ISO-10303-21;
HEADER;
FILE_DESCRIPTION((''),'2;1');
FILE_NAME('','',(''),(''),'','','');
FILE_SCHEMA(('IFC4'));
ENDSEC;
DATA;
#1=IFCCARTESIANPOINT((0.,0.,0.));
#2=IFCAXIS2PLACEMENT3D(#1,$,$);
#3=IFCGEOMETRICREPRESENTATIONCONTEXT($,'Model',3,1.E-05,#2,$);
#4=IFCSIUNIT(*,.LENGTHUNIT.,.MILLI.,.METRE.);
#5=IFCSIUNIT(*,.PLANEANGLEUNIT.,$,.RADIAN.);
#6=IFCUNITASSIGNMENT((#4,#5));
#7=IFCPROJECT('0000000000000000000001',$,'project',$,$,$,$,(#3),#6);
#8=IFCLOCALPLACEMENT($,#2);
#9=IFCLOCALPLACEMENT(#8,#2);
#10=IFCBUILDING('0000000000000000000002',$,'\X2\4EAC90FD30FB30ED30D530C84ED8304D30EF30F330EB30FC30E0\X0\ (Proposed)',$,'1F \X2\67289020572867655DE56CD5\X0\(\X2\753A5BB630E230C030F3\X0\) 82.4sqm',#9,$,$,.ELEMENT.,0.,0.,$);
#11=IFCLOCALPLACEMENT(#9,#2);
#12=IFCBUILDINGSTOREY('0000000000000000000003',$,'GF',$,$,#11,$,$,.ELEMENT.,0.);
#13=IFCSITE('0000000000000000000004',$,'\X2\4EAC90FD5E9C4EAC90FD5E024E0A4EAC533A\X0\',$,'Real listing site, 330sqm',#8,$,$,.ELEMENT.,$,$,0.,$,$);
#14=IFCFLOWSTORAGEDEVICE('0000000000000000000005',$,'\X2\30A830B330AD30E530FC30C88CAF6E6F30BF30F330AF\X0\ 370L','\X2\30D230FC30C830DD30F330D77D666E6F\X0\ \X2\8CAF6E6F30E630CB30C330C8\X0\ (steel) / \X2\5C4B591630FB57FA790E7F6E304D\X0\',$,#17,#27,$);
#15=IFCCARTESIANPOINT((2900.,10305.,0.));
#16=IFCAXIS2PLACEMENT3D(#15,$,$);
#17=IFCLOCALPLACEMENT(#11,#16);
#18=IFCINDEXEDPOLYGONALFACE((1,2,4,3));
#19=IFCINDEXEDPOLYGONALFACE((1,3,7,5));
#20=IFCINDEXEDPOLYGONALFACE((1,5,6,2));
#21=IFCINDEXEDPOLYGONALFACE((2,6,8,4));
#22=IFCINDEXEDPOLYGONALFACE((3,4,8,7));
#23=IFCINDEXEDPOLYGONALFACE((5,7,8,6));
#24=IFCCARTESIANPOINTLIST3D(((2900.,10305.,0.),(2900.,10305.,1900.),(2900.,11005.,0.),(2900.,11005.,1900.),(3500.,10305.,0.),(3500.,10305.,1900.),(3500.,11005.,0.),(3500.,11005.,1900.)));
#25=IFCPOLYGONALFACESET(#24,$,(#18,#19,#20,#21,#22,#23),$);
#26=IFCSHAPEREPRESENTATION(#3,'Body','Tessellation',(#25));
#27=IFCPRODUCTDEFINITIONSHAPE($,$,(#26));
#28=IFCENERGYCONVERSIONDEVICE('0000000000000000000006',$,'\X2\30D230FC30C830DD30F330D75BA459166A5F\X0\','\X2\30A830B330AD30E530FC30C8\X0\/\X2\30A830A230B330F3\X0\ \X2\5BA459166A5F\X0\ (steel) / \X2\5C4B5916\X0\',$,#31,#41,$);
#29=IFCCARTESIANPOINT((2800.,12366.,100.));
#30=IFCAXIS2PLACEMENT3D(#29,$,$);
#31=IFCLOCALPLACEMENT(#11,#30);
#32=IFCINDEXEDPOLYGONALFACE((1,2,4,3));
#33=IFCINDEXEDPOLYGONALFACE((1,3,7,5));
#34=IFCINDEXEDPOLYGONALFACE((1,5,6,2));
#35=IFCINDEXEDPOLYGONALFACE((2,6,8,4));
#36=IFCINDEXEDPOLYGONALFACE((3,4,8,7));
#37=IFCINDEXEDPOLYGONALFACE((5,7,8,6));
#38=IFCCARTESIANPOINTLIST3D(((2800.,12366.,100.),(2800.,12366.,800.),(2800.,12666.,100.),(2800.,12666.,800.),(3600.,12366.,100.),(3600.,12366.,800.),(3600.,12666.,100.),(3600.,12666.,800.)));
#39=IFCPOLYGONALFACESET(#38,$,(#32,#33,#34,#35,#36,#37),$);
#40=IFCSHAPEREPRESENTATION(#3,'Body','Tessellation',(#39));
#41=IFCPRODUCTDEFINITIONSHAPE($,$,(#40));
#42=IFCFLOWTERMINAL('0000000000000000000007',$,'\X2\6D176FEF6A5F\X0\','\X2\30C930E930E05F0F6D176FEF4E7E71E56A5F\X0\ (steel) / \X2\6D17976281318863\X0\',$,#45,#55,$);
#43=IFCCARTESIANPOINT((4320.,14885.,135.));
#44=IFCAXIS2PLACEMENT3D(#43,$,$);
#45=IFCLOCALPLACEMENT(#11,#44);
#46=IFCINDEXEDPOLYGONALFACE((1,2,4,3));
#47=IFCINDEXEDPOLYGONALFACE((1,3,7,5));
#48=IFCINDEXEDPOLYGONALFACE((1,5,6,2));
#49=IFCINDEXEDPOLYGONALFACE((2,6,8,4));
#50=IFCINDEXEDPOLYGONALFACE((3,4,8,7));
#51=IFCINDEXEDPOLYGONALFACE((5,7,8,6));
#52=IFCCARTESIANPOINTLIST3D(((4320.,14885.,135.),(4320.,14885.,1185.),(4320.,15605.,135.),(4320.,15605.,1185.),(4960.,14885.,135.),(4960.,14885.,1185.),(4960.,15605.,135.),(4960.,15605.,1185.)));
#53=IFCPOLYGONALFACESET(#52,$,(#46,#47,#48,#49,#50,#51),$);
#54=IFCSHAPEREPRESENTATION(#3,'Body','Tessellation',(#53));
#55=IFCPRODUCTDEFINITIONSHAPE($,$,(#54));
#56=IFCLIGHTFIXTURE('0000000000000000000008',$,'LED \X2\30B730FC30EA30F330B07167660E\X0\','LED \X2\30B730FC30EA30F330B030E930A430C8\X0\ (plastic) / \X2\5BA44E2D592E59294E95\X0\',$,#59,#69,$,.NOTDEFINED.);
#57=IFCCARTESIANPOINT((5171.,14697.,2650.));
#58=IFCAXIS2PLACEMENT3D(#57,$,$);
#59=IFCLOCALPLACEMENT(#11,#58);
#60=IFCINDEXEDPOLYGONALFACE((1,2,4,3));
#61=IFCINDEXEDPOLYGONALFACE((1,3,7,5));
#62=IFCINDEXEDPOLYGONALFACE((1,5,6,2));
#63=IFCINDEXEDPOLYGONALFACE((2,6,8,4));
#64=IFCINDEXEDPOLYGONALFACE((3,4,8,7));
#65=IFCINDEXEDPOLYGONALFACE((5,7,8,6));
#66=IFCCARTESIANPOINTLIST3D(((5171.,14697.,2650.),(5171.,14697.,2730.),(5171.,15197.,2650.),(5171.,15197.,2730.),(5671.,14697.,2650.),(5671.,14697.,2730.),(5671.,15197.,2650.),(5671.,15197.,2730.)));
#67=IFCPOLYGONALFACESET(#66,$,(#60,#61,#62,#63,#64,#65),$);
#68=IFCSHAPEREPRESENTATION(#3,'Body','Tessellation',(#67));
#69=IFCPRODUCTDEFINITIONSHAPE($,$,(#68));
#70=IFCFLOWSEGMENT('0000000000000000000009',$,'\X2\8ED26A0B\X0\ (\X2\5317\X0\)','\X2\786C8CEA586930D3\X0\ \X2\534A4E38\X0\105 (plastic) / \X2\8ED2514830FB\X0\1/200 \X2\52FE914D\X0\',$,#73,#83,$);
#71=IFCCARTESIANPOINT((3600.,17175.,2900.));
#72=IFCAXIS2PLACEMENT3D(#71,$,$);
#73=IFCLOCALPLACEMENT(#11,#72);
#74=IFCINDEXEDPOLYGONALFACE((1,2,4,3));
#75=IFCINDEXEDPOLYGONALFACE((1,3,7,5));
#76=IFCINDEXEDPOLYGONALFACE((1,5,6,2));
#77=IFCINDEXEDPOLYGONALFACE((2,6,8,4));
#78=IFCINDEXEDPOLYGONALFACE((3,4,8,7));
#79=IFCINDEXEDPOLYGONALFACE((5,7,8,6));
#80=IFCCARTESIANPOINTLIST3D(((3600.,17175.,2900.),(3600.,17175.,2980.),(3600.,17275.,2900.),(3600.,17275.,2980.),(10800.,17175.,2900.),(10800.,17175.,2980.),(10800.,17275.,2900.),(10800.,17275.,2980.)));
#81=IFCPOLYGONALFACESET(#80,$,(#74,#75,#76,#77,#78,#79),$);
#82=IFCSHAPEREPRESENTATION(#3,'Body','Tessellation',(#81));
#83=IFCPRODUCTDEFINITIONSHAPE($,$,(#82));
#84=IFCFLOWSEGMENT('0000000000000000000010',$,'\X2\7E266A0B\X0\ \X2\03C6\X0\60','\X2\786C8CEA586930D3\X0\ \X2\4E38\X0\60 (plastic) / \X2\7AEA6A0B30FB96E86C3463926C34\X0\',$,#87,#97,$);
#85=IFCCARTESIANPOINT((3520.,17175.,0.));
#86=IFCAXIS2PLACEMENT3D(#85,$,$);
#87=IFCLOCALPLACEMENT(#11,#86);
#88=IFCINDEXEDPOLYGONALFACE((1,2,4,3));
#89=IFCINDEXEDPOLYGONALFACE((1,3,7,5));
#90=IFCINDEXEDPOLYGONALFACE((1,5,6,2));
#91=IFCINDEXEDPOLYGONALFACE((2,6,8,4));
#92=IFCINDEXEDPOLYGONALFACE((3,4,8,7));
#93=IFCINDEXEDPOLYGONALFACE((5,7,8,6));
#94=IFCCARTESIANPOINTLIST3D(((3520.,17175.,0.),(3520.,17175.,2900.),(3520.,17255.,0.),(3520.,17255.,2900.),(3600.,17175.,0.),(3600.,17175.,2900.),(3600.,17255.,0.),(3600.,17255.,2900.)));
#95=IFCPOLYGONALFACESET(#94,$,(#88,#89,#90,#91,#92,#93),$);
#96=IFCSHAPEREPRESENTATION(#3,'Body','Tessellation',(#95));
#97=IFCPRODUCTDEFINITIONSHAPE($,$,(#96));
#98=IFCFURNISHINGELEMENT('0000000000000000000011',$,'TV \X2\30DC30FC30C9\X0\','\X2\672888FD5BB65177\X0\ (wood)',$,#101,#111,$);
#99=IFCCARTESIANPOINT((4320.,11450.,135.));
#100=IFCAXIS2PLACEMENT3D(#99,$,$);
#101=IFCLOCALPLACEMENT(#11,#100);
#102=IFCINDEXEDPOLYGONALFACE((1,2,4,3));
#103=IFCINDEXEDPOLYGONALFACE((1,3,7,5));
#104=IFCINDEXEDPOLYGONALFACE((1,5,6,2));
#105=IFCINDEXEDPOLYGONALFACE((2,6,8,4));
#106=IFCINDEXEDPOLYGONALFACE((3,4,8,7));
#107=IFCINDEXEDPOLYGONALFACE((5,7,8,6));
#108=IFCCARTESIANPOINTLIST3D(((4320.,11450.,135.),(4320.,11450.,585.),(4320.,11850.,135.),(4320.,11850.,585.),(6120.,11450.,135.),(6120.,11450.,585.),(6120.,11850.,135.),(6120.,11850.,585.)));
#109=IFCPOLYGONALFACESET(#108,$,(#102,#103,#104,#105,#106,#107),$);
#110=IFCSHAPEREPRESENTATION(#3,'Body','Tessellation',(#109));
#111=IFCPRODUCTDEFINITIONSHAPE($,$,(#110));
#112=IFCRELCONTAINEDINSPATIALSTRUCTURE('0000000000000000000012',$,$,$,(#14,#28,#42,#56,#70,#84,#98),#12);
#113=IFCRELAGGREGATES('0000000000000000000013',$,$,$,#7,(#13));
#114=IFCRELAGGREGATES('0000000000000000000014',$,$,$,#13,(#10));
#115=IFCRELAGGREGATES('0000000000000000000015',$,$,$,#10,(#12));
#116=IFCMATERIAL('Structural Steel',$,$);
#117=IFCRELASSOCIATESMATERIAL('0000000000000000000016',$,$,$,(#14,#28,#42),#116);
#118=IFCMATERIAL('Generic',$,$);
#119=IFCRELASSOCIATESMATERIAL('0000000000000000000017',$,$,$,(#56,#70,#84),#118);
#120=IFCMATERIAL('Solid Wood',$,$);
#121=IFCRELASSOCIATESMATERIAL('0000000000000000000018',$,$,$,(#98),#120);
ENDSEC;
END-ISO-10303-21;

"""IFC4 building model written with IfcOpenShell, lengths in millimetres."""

from ifc_helpers import new_model, si_unit, frame, frame_2d, origin, place, context, project, spatial, rectangle, extrude, material, element, save


model = new_model("IFC4")

# Units and contexts
model_context = context("Model", 3, precision=1e-05, world=origin())
ifc_project = project(units=[si_unit("LENGTHUNIT", "METRE", prefix="MILLI"), si_unit("PLANEANGLEUNIT", "RADIAN")], contexts=[model_context])

# Site, building, storey
site_placement = place(None, origin())
site = spatial("IfcSite", under=ifc_project, at=site_placement, Name="京都府京都市上京区", ObjectType="Real listing site, 330sqm", CompositionType="ELEMENT", RefElevation=0.0)
building_placement = place(site_placement, origin())
building = spatial("IfcBuilding", under=site, at=building_placement, Name="京都・ロフト付きワンルーム (Proposed)", ObjectType="1F 木造在来工法(町家モダン) 82.4sqm", CompositionType="ELEMENT", ElevationOfRefHeight=0.0, ElevationOfTerrain=0.0)
storey_placement = place(building_placement, origin())
storey = spatial("IfcBuildingStorey", under=building, at=storey_placement, Name="GF", CompositionType="ELEMENT", Elevation=0.0)

# Shared definitions
ifc_material_1 = material(Name="Solid Wood")

# Shared definitions
ifc_material_2 = material(Name="Structural Steel")

# Shared definitions
ifc_material_3 = material(Name="Generic")

# Flow storage device
flow_storage_device_placement = place(storey_placement, frame((2900.0, 10305.0, 0.0)))
element("IfcFlowStorageDevice", 1, at=flow_storage_device_placement, inside=storey, material=ifc_material_2, Name="エコキュート貯湯タンク 370L", Description="ヒートポンプ給湯 貯湯ユニット (steel) / 屋外・基礎置き", context=model_context, shape_type="SweptSolid", body=[
    extrude(rectangle(XDim=600.0, YDim=700.0, at=frame_2d((300.0, 350.0))), frame((2900.0, 10305.0, 0.0)), (0.0, 0.0, 1.0), 1900.0),
])

# Energy conversion device
energy_conversion_device_placement = place(storey_placement, frame((2800.0, 12366.0, 100.0)))
element("IfcEnergyConversionDevice", 2, at=energy_conversion_device_placement, inside=storey, material=ifc_material_2, Name="ヒートポンプ室外機", Description="エコキュート/エアコン 室外機 (steel) / 屋外", context=model_context, shape_type="SweptSolid", body=[
    extrude(rectangle(XDim=800.0, YDim=300.0, at=frame_2d((400.0, 150.0))), frame((2800.0, 12366.0, 100.0)), (0.0, 0.0, 1.0), 700.0),
])

# Flow terminal
flow_terminal_placement = place(storey_placement, frame((4320.0, 14885.0, 135.0)))
element("IfcFlowTerminal", 3, at=flow_terminal_placement, inside=storey, material=ifc_material_2, Name="洗濯機", Description="ドラム式洗濯乾燥機 (steel) / 洗面脱衣", context=model_context, shape_type="SweptSolid", body=[
    extrude(rectangle(XDim=640.0, YDim=720.0, at=frame_2d((320.0, 360.0))), frame((4320.0, 14885.0, 135.0)), (0.0, 0.0, 1.0), 1050.0),
])

# Light fixture
light_fixture_placement = place(storey_placement, frame((5171.0, 14697.0, 2650.0)))
element("IfcLightFixture", 4, at=light_fixture_placement, inside=storey, material=ifc_material_3, Name="LED シーリング照明", Description="LED シーリングライト (plastic) / 室中央天井", PredefinedType="NOTDEFINED", context=model_context, shape_type="SweptSolid", body=[
    extrude(rectangle(XDim=500.0, YDim=500.0, at=frame_2d((250.0, 250.0))), frame((5171.0, 14697.0, 2650.0)), (0.0, 0.0, 1.0), 80.0),
])

# Flow segments
flow_segment_1_placement = place(storey_placement, frame((3600.0, 17175.0, 2900.0)))
element("IfcFlowSegment", 5, at=flow_segment_1_placement, inside=storey, material=ifc_material_3, Name="軒樋 (北)", Description="硬質塩ビ 半丸105 (plastic) / 軒先・1/200 勾配", context=model_context, shape_type="SweptSolid", body=[
    extrude(rectangle(XDim=7200.0, YDim=100.0, at=frame_2d((3600.0, 50.0))), frame((3600.0, 17175.0, 2900.0)), (0.0, 0.0, 1.0), 80.0),
])
flow_segment_2_placement = place(storey_placement, frame((3520.0, 17175.0, 0.0)))
element("IfcFlowSegment", 6, at=flow_segment_2_placement, inside=storey, material=ifc_material_3, Name="縦樋 φ60", Description="硬質塩ビ 丸60 (plastic) / 竪樋・雨水排水", context=model_context, shape_type="SweptSolid", body=[
    extrude(rectangle(XDim=80.0, YDim=80.0, at=frame_2d((40.0, 40.0))), frame((3520.0, 17175.0, 0.0)), (0.0, 0.0, 1.0), 2900.0),
])

# Furnishing element
furnishing_placement = place(storey_placement, frame((4320.0, 11450.0, 135.0)))
element("IfcFurnishingElement", 7, at=furnishing_placement, inside=storey, material=ifc_material_1, Name="TV ボード", Description="木製家具 (wood)", context=model_context, shape_type="SweptSolid", body=[
    extrude(rectangle(XDim=1800.0, YDim=400.0, at=frame_2d((900.0, 200.0))), frame((4320.0, 11450.0, 135.0)), (0.0, 0.0, 1.0), 450.0),
])

save(model, "model.ifc")
